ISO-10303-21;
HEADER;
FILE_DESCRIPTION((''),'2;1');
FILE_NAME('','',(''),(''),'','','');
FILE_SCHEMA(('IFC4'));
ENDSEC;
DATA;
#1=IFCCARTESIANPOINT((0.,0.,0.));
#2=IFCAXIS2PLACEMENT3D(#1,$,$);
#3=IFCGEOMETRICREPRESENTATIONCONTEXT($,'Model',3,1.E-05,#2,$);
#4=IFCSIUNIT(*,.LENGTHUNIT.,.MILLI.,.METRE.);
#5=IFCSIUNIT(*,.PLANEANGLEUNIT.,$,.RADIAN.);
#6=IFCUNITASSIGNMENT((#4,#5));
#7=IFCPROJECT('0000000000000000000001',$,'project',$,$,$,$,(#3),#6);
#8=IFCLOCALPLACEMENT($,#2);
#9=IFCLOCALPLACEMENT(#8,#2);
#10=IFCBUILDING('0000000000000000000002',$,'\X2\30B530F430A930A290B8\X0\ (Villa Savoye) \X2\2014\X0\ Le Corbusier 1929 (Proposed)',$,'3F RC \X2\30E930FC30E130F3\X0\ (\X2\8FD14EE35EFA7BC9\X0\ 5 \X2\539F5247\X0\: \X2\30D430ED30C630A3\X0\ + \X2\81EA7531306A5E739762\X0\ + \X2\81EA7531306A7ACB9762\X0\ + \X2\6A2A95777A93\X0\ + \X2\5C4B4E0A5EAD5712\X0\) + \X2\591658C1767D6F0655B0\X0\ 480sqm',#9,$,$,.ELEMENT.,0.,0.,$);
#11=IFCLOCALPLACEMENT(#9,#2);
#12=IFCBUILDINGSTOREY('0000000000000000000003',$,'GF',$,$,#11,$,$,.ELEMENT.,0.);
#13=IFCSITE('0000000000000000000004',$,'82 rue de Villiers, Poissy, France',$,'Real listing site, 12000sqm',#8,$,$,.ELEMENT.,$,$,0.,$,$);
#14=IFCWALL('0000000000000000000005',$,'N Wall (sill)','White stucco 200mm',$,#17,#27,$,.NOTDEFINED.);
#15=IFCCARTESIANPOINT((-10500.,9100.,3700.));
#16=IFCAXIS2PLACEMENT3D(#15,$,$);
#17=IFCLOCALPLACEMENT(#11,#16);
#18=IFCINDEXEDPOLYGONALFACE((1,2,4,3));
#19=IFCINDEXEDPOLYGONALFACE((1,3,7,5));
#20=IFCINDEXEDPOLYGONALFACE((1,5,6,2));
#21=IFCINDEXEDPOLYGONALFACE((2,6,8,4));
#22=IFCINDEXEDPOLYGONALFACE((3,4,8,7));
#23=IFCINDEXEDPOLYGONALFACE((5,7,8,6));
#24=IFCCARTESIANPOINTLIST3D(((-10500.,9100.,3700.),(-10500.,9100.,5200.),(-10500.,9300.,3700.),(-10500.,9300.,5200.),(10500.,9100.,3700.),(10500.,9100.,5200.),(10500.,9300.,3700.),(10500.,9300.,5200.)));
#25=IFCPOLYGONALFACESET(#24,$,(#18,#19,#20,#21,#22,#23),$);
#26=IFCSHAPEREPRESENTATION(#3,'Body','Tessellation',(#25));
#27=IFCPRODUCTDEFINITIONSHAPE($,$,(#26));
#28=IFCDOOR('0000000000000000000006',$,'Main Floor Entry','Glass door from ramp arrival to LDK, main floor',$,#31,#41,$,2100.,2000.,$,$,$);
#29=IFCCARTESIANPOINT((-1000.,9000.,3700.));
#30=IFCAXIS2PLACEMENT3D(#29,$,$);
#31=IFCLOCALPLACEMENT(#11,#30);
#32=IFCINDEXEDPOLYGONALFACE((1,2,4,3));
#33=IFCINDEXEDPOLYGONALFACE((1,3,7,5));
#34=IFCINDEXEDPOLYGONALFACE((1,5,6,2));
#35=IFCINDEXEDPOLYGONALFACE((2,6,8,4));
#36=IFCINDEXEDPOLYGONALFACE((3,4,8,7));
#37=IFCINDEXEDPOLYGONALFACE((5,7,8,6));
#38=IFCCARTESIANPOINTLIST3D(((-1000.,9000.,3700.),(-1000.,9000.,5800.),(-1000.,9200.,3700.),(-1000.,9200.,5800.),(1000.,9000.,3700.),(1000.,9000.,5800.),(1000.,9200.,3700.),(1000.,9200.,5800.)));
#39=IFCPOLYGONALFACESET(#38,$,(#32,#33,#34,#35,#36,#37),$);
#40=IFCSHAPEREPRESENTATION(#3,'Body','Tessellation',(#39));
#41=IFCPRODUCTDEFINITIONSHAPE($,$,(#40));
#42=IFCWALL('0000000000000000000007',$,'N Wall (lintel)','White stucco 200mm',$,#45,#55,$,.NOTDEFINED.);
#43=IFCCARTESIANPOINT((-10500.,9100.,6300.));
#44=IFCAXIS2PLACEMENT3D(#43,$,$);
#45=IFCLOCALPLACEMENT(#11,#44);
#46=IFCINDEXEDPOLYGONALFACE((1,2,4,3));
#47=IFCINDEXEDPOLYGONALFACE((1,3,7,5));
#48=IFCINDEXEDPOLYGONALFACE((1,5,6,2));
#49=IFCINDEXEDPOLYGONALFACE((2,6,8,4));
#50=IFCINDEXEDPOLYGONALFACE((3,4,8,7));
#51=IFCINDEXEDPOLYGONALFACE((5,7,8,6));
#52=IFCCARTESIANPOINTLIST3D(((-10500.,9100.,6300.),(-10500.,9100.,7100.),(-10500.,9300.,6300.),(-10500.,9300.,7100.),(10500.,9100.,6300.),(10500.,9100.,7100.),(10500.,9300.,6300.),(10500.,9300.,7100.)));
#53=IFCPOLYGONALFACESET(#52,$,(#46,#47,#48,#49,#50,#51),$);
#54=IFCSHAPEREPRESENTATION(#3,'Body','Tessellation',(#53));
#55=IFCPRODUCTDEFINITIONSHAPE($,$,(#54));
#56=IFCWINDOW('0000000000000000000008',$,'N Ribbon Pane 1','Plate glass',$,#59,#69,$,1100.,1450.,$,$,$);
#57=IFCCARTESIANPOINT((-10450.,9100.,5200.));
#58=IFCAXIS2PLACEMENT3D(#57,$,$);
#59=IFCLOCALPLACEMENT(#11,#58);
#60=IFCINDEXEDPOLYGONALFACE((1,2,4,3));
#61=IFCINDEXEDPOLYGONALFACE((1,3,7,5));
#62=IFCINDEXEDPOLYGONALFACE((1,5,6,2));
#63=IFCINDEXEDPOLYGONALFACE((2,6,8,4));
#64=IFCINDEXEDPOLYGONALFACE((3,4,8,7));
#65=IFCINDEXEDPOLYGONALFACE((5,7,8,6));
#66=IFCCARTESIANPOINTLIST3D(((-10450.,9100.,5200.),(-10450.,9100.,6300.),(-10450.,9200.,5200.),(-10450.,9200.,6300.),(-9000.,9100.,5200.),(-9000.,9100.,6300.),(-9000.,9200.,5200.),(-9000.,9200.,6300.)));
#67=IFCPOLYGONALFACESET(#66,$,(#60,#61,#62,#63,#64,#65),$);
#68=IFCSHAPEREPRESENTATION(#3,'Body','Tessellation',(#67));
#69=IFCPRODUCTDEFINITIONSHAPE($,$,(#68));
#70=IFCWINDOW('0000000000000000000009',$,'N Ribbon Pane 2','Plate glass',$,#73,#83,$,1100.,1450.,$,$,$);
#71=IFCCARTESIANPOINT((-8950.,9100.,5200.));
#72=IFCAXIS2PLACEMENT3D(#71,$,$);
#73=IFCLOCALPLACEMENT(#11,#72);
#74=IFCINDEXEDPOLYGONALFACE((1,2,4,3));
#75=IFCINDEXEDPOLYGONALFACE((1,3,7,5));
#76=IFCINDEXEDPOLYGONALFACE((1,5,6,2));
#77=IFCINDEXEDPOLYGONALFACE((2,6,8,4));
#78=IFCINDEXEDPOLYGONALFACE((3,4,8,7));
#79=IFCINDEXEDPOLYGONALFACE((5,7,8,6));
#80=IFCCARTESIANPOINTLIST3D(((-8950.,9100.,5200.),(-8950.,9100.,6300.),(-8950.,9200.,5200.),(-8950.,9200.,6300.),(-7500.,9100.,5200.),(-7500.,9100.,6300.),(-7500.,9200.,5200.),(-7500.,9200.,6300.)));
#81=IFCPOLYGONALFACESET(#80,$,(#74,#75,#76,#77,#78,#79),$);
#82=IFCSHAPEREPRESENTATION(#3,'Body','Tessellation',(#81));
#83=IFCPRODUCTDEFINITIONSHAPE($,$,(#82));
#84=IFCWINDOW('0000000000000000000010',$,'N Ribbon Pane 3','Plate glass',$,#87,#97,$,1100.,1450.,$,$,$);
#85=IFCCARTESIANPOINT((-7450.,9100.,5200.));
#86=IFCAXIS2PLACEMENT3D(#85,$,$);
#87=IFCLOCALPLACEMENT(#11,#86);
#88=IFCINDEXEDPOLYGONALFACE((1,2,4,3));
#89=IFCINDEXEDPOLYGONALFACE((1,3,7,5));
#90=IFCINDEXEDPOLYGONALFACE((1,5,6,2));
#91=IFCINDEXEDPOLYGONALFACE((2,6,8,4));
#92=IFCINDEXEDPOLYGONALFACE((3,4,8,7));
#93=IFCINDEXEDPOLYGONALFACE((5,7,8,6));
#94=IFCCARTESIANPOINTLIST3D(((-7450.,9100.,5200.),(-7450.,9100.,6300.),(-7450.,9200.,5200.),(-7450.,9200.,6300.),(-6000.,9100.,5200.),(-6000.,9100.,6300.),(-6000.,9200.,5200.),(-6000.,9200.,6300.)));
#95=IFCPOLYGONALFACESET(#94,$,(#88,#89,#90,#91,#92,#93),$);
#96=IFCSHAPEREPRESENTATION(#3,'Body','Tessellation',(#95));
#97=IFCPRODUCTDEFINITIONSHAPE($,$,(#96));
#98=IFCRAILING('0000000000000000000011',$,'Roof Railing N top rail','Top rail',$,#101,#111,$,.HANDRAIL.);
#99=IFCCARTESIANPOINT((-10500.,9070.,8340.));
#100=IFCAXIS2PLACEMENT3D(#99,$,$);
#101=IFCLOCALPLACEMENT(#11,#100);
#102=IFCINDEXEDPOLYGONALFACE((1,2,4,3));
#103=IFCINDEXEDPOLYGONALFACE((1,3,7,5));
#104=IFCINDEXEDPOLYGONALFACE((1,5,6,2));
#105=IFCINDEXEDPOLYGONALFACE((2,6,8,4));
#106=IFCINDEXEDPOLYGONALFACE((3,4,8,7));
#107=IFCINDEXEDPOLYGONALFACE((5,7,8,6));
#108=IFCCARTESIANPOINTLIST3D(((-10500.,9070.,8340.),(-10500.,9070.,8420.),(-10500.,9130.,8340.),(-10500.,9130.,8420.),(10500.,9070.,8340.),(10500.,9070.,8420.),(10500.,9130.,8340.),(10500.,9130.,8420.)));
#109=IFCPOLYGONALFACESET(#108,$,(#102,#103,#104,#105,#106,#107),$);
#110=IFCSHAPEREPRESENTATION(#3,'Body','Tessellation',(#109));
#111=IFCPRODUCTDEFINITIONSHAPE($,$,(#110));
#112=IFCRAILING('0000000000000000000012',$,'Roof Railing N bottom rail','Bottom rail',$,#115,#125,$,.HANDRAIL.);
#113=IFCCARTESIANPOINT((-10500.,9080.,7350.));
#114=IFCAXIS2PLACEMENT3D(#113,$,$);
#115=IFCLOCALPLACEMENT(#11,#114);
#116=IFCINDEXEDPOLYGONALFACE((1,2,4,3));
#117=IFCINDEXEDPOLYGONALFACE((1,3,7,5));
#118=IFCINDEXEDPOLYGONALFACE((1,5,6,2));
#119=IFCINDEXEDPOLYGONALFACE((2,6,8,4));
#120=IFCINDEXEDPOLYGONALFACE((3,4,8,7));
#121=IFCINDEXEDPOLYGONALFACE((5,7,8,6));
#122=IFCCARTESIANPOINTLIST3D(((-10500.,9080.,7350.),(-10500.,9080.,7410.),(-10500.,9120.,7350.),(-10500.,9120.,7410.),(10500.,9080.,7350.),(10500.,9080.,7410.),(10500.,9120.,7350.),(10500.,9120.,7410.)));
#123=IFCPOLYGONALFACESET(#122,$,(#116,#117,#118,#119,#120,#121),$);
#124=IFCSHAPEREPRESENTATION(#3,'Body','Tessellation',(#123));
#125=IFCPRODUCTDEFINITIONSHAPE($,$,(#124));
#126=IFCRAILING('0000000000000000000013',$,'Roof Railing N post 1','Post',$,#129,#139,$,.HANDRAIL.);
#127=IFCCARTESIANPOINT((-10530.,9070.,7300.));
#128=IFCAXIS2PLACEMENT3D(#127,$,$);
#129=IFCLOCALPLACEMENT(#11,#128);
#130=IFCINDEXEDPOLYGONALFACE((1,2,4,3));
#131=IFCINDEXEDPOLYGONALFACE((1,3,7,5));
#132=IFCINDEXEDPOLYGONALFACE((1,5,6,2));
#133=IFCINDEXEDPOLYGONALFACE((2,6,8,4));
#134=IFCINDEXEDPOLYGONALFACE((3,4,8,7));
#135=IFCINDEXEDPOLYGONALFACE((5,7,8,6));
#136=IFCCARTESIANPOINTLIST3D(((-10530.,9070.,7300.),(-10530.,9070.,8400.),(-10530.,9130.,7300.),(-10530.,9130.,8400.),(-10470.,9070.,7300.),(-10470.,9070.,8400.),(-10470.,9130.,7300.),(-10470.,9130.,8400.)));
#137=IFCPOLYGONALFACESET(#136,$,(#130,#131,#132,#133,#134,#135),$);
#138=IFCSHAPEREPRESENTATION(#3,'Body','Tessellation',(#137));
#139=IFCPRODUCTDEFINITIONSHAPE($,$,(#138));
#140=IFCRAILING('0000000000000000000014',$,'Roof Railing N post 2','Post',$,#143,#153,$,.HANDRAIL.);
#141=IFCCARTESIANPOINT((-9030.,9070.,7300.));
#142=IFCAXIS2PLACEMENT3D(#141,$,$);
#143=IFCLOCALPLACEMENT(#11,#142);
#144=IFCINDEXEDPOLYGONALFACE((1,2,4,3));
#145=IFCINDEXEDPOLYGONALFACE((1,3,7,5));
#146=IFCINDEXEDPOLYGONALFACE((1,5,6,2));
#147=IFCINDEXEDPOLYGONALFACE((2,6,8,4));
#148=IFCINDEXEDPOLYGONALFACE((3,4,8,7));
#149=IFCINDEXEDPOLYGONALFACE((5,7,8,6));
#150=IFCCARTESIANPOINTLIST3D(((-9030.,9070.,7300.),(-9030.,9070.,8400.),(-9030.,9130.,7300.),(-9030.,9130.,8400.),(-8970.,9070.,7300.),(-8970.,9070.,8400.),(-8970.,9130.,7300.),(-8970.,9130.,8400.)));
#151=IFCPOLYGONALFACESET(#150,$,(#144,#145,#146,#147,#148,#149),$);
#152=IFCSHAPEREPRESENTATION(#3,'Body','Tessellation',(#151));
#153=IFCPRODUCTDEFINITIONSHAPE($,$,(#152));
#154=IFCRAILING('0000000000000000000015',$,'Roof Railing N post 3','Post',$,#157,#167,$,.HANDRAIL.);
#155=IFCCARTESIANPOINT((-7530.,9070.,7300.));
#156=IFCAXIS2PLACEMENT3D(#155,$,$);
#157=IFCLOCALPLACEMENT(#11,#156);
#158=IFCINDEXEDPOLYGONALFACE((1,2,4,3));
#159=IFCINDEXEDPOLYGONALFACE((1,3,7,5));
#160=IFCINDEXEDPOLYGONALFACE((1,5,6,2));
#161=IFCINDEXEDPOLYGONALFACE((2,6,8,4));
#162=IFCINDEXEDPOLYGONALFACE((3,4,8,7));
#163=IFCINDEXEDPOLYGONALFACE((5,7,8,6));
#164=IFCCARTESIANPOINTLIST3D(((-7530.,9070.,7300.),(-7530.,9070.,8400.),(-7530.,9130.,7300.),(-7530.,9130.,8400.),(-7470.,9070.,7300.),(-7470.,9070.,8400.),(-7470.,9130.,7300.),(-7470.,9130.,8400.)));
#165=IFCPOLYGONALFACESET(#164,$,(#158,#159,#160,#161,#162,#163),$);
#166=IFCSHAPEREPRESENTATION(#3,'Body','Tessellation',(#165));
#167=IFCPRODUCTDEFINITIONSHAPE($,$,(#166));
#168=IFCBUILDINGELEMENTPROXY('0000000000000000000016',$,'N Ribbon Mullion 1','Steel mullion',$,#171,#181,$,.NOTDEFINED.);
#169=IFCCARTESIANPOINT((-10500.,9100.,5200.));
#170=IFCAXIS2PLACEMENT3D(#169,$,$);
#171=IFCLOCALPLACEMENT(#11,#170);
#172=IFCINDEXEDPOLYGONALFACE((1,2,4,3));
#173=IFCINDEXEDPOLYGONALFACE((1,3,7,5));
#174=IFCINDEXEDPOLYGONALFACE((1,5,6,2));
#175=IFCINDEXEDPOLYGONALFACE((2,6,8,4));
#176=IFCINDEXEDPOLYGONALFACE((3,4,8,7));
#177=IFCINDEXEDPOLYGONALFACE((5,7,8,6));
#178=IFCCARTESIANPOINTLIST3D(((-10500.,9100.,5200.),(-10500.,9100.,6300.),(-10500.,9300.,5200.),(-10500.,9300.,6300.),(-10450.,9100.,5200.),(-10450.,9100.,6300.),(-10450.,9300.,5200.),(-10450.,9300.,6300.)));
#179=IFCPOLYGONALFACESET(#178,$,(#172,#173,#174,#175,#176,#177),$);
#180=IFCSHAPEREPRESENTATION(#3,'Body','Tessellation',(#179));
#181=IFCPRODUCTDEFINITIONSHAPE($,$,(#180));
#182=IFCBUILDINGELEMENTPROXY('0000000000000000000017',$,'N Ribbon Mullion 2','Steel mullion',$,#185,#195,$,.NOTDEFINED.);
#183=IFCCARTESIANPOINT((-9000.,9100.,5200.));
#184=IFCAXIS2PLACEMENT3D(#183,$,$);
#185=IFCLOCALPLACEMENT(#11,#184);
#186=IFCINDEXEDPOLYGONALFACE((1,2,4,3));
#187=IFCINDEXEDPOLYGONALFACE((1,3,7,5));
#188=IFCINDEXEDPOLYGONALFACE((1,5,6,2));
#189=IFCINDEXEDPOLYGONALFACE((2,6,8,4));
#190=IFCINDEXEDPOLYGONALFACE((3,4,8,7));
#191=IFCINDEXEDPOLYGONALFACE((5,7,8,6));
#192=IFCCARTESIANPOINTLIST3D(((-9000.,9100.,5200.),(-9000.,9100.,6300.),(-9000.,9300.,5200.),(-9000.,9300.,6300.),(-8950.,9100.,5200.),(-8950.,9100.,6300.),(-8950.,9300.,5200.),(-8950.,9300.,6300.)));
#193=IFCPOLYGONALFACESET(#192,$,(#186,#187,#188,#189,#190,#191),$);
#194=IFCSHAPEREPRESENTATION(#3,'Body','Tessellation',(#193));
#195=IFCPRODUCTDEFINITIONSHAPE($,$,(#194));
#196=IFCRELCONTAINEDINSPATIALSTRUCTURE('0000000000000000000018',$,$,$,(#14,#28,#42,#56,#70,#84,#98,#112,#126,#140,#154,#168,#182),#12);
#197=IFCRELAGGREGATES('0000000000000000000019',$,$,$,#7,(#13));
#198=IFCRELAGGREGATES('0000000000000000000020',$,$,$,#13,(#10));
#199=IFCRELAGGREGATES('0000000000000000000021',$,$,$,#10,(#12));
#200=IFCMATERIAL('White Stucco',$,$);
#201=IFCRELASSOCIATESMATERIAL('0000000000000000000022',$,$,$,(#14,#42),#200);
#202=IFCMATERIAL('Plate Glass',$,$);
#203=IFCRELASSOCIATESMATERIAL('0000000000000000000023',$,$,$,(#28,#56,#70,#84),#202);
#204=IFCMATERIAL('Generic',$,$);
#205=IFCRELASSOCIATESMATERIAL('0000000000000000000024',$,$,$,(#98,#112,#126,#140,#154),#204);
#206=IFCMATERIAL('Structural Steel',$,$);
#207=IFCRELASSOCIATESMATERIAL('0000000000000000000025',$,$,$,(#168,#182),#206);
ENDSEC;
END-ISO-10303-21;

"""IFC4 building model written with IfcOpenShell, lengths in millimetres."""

from ifc_helpers import new_model, si_unit, frame, frame_2d, origin, place, context, project, spatial, rectangle, extrude, material, element, fill, save


model = new_model("IFC4")

# Units and contexts
model_context = context("Model", 3, precision=1e-05, world=origin())
ifc_project = project(units=[si_unit("LENGTHUNIT", "METRE", prefix="MILLI"), si_unit("PLANEANGLEUNIT", "RADIAN")], contexts=[model_context])

# Site, building, storey
site_placement = place(None, origin())
site = spatial("IfcSite", under=ifc_project, at=site_placement, Name="82 rue de Villiers, Poissy, France", ObjectType="Real listing site, 12000sqm", CompositionType="ELEMENT", RefElevation=0.0)
building_placement = place(site_placement, origin())
building = spatial("IfcBuilding", under=site, at=building_placement, Name="サヴォア邸 (Villa Savoye) — Le Corbusier 1929 (Proposed)", ObjectType="3F RC ラーメン (近代建築 5 原則: ピロティ + 自由な平面 + 自由な立面 + 横長窓 + 屋上庭園) + 外壁白漆喰 480sqm", CompositionType="ELEMENT", ElevationOfRefHeight=0.0, ElevationOfTerrain=0.0)
storey_placement = place(building_placement, origin())
storey = spatial("IfcBuildingStorey", under=building, at=storey_placement, Name="GF", CompositionType="ELEMENT", Elevation=0.0)

# Wall, opening, door
ifc_material_1 = material(Name="White Stucco")
wall_1_placement = place(storey_placement, frame((-10500.0, 9100.0, 3700.0)))
wall_1 = element("IfcWall", 1, at=wall_1_placement, inside=storey, material=ifc_material_1, Name="N Wall (sill)", Description="White stucco 200mm", PredefinedType="NOTDEFINED", context=model_context, shape_type="SweptSolid", body=[
    extrude(rectangle(XDim=21000.0, YDim=200.0, at=frame_2d((10500.0, 100.0))), frame((-10500.0, 9100.0, 3700.0)), (0.0, 0.0, 1.0), 1500.0),
])
opening_placement = place(storey_placement, frame((-1000.0, 9000.0, 3700.0)))
opening = element("IfcOpeningElement", 2, at=opening_placement, cuts=wall_1, PredefinedType="NOTDEFINED", context=model_context, shape_type="SweptSolid", body=[
    extrude(rectangle(XDim=2000.0, YDim=200.0, at=frame_2d((1000.0, 100.0))), frame((-1000.0, 9000.0, 3700.0)), (0.0, 0.0, 1.0), 2100.0),
])
ifc_material_2 = material(Name="Plate Glass")
door_placement = place(storey_placement, frame((-1000.0, 9000.0, 3700.0)))
door = element("IfcDoor", 3, at=door_placement, inside=storey, material=ifc_material_2, Name="Main Floor Entry", Description="Glass door from ramp arrival to LDK, main floor", OverallHeight=2100.0, OverallWidth=2000.0, context=model_context, shape_type="SweptSolid", body=[
    extrude(rectangle(XDim=2000.0, YDim=200.0, at=frame_2d((1000.0, 100.0))), frame((-1000.0, 9000.0, 3700.0)), (0.0, 0.0, 1.0), 2100.0),
])
fill(opening, door)

# Wall
wall_2_placement = place(storey_placement, frame((-10500.0, 9100.0, 6300.0)))
element("IfcWall", 4, at=wall_2_placement, inside=storey, material=ifc_material_1, Name="N Wall (lintel)", Description="White stucco 200mm", PredefinedType="NOTDEFINED", context=model_context, shape_type="SweptSolid", body=[
    extrude(rectangle(XDim=21000.0, YDim=200.0, at=frame_2d((10500.0, 100.0))), frame((-10500.0, 9100.0, 6300.0)), (0.0, 0.0, 1.0), 800.0),
])

# Windows
window_1_placement = place(storey_placement, frame((-10450.0, 9100.0, 5200.0)))
element("IfcWindow", 5, at=window_1_placement, inside=storey, material=ifc_material_2, Name="N Ribbon Pane 1", Description="Plate glass", OverallHeight=1100.0, OverallWidth=1450.0, context=model_context, shape_type="SweptSolid", body=[
    extrude(rectangle(XDim=1450.0, YDim=100.0, at=frame_2d((725.0, 50.0))), frame((-10450.0, 9100.0, 5200.0)), (0.0, 0.0, 1.0), 1100.0),
])
window_2_placement = place(storey_placement, frame((-8950.0, 9100.0, 5200.0)))
element("IfcWindow", 6, at=window_2_placement, inside=storey, material=ifc_material_2, Name="N Ribbon Pane 2", Description="Plate glass", OverallHeight=1100.0, OverallWidth=1450.0, context=model_context, shape_type="SweptSolid", body=[
    extrude(rectangle(XDim=1450.0, YDim=100.0, at=frame_2d((725.0, 50.0))), frame((-8950.0, 9100.0, 5200.0)), (0.0, 0.0, 1.0), 1100.0),
])
window_3_placement = place(storey_placement, frame((-7450.0, 9100.0, 5200.0)))
element("IfcWindow", 7, at=window_3_placement, inside=storey, material=ifc_material_2, Name="N Ribbon Pane 3", Description="Plate glass", OverallHeight=1100.0, OverallWidth=1450.0, context=model_context, shape_type="SweptSolid", body=[
    extrude(rectangle(XDim=1450.0, YDim=100.0, at=frame_2d((725.0, 50.0))), frame((-7450.0, 9100.0, 5200.0)), (0.0, 0.0, 1.0), 1100.0),
])

# Railings
ifc_material_3 = material(Name="Generic")
railing_1_placement = place(storey_placement, frame((-10500.0, 9070.0, 8340.0)))
element("IfcRailing", 8, at=railing_1_placement, inside=storey, material=ifc_material_3, Name="Roof Railing N top rail", Description="Top rail", PredefinedType="HANDRAIL", context=model_context, shape_type="SweptSolid", body=[
    extrude(rectangle(XDim=21000.0, YDim=60.0, at=frame_2d((10500.0, 30.0))), frame((-10500.0, 9070.0, 8340.0)), (0.0, 0.0, 1.0), 80.0),
])
railing_2_placement = place(storey_placement, frame((-10500.0, 9080.0, 7350.0)))
element("IfcRailing", 9, at=railing_2_placement, inside=storey, material=ifc_material_3, Name="Roof Railing N bottom rail", Description="Bottom rail", PredefinedType="HANDRAIL", context=model_context, shape_type="SweptSolid", body=[
    extrude(rectangle(XDim=21000.0, YDim=40.0, at=frame_2d((10500.0, 20.0))), frame((-10500.0, 9080.0, 7350.0)), (0.0, 0.0, 1.0), 60.0),
])
railing_3_placement = place(storey_placement, frame((-10530.0, 9070.0, 7300.0)))
element("IfcRailing", 10, at=railing_3_placement, inside=storey, material=ifc_material_3, Name="Roof Railing N post 1", Description="Post", PredefinedType="HANDRAIL", context=model_context, shape_type="SweptSolid", body=[
    extrude(rectangle(XDim=60.0, YDim=60.0, at=frame_2d((30.0, 30.0))), frame((-10530.0, 9070.0, 7300.0)), (0.0, 0.0, 1.0), 1100.0),
])
railing_4_placement = place(storey_placement, frame((-9030.0, 9070.0, 7300.0)))
element("IfcRailing", 11, at=railing_4_placement, inside=storey, material=ifc_material_3, Name="Roof Railing N post 2", Description="Post", PredefinedType="HANDRAIL", context=model_context, shape_type="SweptSolid", body=[
    extrude(rectangle(XDim=60.0, YDim=60.0, at=frame_2d((30.0, 30.0))), frame((-9030.0, 9070.0, 7300.0)), (0.0, 0.0, 1.0), 1100.0),
])
railing_5_placement = place(storey_placement, frame((-7530.0, 9070.0, 7300.0)))
element("IfcRailing", 12, at=railing_5_placement, inside=storey, material=ifc_material_3, Name="Roof Railing N post 3", Description="Post", PredefinedType="HANDRAIL", context=model_context, shape_type="SweptSolid", body=[
    extrude(rectangle(XDim=60.0, YDim=60.0, at=frame_2d((30.0, 30.0))), frame((-7530.0, 9070.0, 7300.0)), (0.0, 0.0, 1.0), 1100.0),
])

# Building element proxies
ifc_material_4 = material(Name="Structural Steel")
proxy_1_placement = place(storey_placement, frame((-10500.0, 9100.0, 5200.0)))
element("IfcBuildingElementProxy", 13, at=proxy_1_placement, inside=storey, material=ifc_material_4, Name="N Ribbon Mullion 1", Description="Steel mullion", PredefinedType="NOTDEFINED", context=model_context, shape_type="SweptSolid", body=[
    extrude(rectangle(XDim=50.0, YDim=200.0, at=frame_2d((25.0, 100.0))), frame((-10500.0, 9100.0, 5200.0)), (0.0, 0.0, 1.0), 1100.0),
])
proxy_2_placement = place(storey_placement, frame((-9000.0, 9100.0, 5200.0)))
element("IfcBuildingElementProxy", 14, at=proxy_2_placement, inside=storey, material=ifc_material_4, Name="N Ribbon Mullion 2", Description="Steel mullion", PredefinedType="NOTDEFINED", context=model_context, shape_type="SweptSolid", body=[
    extrude(rectangle(XDim=50.0, YDim=200.0, at=frame_2d((25.0, 100.0))), frame((-9000.0, 9100.0, 5200.0)), (0.0, 0.0, 1.0), 1100.0),
])

save(model, "model.ifc")
